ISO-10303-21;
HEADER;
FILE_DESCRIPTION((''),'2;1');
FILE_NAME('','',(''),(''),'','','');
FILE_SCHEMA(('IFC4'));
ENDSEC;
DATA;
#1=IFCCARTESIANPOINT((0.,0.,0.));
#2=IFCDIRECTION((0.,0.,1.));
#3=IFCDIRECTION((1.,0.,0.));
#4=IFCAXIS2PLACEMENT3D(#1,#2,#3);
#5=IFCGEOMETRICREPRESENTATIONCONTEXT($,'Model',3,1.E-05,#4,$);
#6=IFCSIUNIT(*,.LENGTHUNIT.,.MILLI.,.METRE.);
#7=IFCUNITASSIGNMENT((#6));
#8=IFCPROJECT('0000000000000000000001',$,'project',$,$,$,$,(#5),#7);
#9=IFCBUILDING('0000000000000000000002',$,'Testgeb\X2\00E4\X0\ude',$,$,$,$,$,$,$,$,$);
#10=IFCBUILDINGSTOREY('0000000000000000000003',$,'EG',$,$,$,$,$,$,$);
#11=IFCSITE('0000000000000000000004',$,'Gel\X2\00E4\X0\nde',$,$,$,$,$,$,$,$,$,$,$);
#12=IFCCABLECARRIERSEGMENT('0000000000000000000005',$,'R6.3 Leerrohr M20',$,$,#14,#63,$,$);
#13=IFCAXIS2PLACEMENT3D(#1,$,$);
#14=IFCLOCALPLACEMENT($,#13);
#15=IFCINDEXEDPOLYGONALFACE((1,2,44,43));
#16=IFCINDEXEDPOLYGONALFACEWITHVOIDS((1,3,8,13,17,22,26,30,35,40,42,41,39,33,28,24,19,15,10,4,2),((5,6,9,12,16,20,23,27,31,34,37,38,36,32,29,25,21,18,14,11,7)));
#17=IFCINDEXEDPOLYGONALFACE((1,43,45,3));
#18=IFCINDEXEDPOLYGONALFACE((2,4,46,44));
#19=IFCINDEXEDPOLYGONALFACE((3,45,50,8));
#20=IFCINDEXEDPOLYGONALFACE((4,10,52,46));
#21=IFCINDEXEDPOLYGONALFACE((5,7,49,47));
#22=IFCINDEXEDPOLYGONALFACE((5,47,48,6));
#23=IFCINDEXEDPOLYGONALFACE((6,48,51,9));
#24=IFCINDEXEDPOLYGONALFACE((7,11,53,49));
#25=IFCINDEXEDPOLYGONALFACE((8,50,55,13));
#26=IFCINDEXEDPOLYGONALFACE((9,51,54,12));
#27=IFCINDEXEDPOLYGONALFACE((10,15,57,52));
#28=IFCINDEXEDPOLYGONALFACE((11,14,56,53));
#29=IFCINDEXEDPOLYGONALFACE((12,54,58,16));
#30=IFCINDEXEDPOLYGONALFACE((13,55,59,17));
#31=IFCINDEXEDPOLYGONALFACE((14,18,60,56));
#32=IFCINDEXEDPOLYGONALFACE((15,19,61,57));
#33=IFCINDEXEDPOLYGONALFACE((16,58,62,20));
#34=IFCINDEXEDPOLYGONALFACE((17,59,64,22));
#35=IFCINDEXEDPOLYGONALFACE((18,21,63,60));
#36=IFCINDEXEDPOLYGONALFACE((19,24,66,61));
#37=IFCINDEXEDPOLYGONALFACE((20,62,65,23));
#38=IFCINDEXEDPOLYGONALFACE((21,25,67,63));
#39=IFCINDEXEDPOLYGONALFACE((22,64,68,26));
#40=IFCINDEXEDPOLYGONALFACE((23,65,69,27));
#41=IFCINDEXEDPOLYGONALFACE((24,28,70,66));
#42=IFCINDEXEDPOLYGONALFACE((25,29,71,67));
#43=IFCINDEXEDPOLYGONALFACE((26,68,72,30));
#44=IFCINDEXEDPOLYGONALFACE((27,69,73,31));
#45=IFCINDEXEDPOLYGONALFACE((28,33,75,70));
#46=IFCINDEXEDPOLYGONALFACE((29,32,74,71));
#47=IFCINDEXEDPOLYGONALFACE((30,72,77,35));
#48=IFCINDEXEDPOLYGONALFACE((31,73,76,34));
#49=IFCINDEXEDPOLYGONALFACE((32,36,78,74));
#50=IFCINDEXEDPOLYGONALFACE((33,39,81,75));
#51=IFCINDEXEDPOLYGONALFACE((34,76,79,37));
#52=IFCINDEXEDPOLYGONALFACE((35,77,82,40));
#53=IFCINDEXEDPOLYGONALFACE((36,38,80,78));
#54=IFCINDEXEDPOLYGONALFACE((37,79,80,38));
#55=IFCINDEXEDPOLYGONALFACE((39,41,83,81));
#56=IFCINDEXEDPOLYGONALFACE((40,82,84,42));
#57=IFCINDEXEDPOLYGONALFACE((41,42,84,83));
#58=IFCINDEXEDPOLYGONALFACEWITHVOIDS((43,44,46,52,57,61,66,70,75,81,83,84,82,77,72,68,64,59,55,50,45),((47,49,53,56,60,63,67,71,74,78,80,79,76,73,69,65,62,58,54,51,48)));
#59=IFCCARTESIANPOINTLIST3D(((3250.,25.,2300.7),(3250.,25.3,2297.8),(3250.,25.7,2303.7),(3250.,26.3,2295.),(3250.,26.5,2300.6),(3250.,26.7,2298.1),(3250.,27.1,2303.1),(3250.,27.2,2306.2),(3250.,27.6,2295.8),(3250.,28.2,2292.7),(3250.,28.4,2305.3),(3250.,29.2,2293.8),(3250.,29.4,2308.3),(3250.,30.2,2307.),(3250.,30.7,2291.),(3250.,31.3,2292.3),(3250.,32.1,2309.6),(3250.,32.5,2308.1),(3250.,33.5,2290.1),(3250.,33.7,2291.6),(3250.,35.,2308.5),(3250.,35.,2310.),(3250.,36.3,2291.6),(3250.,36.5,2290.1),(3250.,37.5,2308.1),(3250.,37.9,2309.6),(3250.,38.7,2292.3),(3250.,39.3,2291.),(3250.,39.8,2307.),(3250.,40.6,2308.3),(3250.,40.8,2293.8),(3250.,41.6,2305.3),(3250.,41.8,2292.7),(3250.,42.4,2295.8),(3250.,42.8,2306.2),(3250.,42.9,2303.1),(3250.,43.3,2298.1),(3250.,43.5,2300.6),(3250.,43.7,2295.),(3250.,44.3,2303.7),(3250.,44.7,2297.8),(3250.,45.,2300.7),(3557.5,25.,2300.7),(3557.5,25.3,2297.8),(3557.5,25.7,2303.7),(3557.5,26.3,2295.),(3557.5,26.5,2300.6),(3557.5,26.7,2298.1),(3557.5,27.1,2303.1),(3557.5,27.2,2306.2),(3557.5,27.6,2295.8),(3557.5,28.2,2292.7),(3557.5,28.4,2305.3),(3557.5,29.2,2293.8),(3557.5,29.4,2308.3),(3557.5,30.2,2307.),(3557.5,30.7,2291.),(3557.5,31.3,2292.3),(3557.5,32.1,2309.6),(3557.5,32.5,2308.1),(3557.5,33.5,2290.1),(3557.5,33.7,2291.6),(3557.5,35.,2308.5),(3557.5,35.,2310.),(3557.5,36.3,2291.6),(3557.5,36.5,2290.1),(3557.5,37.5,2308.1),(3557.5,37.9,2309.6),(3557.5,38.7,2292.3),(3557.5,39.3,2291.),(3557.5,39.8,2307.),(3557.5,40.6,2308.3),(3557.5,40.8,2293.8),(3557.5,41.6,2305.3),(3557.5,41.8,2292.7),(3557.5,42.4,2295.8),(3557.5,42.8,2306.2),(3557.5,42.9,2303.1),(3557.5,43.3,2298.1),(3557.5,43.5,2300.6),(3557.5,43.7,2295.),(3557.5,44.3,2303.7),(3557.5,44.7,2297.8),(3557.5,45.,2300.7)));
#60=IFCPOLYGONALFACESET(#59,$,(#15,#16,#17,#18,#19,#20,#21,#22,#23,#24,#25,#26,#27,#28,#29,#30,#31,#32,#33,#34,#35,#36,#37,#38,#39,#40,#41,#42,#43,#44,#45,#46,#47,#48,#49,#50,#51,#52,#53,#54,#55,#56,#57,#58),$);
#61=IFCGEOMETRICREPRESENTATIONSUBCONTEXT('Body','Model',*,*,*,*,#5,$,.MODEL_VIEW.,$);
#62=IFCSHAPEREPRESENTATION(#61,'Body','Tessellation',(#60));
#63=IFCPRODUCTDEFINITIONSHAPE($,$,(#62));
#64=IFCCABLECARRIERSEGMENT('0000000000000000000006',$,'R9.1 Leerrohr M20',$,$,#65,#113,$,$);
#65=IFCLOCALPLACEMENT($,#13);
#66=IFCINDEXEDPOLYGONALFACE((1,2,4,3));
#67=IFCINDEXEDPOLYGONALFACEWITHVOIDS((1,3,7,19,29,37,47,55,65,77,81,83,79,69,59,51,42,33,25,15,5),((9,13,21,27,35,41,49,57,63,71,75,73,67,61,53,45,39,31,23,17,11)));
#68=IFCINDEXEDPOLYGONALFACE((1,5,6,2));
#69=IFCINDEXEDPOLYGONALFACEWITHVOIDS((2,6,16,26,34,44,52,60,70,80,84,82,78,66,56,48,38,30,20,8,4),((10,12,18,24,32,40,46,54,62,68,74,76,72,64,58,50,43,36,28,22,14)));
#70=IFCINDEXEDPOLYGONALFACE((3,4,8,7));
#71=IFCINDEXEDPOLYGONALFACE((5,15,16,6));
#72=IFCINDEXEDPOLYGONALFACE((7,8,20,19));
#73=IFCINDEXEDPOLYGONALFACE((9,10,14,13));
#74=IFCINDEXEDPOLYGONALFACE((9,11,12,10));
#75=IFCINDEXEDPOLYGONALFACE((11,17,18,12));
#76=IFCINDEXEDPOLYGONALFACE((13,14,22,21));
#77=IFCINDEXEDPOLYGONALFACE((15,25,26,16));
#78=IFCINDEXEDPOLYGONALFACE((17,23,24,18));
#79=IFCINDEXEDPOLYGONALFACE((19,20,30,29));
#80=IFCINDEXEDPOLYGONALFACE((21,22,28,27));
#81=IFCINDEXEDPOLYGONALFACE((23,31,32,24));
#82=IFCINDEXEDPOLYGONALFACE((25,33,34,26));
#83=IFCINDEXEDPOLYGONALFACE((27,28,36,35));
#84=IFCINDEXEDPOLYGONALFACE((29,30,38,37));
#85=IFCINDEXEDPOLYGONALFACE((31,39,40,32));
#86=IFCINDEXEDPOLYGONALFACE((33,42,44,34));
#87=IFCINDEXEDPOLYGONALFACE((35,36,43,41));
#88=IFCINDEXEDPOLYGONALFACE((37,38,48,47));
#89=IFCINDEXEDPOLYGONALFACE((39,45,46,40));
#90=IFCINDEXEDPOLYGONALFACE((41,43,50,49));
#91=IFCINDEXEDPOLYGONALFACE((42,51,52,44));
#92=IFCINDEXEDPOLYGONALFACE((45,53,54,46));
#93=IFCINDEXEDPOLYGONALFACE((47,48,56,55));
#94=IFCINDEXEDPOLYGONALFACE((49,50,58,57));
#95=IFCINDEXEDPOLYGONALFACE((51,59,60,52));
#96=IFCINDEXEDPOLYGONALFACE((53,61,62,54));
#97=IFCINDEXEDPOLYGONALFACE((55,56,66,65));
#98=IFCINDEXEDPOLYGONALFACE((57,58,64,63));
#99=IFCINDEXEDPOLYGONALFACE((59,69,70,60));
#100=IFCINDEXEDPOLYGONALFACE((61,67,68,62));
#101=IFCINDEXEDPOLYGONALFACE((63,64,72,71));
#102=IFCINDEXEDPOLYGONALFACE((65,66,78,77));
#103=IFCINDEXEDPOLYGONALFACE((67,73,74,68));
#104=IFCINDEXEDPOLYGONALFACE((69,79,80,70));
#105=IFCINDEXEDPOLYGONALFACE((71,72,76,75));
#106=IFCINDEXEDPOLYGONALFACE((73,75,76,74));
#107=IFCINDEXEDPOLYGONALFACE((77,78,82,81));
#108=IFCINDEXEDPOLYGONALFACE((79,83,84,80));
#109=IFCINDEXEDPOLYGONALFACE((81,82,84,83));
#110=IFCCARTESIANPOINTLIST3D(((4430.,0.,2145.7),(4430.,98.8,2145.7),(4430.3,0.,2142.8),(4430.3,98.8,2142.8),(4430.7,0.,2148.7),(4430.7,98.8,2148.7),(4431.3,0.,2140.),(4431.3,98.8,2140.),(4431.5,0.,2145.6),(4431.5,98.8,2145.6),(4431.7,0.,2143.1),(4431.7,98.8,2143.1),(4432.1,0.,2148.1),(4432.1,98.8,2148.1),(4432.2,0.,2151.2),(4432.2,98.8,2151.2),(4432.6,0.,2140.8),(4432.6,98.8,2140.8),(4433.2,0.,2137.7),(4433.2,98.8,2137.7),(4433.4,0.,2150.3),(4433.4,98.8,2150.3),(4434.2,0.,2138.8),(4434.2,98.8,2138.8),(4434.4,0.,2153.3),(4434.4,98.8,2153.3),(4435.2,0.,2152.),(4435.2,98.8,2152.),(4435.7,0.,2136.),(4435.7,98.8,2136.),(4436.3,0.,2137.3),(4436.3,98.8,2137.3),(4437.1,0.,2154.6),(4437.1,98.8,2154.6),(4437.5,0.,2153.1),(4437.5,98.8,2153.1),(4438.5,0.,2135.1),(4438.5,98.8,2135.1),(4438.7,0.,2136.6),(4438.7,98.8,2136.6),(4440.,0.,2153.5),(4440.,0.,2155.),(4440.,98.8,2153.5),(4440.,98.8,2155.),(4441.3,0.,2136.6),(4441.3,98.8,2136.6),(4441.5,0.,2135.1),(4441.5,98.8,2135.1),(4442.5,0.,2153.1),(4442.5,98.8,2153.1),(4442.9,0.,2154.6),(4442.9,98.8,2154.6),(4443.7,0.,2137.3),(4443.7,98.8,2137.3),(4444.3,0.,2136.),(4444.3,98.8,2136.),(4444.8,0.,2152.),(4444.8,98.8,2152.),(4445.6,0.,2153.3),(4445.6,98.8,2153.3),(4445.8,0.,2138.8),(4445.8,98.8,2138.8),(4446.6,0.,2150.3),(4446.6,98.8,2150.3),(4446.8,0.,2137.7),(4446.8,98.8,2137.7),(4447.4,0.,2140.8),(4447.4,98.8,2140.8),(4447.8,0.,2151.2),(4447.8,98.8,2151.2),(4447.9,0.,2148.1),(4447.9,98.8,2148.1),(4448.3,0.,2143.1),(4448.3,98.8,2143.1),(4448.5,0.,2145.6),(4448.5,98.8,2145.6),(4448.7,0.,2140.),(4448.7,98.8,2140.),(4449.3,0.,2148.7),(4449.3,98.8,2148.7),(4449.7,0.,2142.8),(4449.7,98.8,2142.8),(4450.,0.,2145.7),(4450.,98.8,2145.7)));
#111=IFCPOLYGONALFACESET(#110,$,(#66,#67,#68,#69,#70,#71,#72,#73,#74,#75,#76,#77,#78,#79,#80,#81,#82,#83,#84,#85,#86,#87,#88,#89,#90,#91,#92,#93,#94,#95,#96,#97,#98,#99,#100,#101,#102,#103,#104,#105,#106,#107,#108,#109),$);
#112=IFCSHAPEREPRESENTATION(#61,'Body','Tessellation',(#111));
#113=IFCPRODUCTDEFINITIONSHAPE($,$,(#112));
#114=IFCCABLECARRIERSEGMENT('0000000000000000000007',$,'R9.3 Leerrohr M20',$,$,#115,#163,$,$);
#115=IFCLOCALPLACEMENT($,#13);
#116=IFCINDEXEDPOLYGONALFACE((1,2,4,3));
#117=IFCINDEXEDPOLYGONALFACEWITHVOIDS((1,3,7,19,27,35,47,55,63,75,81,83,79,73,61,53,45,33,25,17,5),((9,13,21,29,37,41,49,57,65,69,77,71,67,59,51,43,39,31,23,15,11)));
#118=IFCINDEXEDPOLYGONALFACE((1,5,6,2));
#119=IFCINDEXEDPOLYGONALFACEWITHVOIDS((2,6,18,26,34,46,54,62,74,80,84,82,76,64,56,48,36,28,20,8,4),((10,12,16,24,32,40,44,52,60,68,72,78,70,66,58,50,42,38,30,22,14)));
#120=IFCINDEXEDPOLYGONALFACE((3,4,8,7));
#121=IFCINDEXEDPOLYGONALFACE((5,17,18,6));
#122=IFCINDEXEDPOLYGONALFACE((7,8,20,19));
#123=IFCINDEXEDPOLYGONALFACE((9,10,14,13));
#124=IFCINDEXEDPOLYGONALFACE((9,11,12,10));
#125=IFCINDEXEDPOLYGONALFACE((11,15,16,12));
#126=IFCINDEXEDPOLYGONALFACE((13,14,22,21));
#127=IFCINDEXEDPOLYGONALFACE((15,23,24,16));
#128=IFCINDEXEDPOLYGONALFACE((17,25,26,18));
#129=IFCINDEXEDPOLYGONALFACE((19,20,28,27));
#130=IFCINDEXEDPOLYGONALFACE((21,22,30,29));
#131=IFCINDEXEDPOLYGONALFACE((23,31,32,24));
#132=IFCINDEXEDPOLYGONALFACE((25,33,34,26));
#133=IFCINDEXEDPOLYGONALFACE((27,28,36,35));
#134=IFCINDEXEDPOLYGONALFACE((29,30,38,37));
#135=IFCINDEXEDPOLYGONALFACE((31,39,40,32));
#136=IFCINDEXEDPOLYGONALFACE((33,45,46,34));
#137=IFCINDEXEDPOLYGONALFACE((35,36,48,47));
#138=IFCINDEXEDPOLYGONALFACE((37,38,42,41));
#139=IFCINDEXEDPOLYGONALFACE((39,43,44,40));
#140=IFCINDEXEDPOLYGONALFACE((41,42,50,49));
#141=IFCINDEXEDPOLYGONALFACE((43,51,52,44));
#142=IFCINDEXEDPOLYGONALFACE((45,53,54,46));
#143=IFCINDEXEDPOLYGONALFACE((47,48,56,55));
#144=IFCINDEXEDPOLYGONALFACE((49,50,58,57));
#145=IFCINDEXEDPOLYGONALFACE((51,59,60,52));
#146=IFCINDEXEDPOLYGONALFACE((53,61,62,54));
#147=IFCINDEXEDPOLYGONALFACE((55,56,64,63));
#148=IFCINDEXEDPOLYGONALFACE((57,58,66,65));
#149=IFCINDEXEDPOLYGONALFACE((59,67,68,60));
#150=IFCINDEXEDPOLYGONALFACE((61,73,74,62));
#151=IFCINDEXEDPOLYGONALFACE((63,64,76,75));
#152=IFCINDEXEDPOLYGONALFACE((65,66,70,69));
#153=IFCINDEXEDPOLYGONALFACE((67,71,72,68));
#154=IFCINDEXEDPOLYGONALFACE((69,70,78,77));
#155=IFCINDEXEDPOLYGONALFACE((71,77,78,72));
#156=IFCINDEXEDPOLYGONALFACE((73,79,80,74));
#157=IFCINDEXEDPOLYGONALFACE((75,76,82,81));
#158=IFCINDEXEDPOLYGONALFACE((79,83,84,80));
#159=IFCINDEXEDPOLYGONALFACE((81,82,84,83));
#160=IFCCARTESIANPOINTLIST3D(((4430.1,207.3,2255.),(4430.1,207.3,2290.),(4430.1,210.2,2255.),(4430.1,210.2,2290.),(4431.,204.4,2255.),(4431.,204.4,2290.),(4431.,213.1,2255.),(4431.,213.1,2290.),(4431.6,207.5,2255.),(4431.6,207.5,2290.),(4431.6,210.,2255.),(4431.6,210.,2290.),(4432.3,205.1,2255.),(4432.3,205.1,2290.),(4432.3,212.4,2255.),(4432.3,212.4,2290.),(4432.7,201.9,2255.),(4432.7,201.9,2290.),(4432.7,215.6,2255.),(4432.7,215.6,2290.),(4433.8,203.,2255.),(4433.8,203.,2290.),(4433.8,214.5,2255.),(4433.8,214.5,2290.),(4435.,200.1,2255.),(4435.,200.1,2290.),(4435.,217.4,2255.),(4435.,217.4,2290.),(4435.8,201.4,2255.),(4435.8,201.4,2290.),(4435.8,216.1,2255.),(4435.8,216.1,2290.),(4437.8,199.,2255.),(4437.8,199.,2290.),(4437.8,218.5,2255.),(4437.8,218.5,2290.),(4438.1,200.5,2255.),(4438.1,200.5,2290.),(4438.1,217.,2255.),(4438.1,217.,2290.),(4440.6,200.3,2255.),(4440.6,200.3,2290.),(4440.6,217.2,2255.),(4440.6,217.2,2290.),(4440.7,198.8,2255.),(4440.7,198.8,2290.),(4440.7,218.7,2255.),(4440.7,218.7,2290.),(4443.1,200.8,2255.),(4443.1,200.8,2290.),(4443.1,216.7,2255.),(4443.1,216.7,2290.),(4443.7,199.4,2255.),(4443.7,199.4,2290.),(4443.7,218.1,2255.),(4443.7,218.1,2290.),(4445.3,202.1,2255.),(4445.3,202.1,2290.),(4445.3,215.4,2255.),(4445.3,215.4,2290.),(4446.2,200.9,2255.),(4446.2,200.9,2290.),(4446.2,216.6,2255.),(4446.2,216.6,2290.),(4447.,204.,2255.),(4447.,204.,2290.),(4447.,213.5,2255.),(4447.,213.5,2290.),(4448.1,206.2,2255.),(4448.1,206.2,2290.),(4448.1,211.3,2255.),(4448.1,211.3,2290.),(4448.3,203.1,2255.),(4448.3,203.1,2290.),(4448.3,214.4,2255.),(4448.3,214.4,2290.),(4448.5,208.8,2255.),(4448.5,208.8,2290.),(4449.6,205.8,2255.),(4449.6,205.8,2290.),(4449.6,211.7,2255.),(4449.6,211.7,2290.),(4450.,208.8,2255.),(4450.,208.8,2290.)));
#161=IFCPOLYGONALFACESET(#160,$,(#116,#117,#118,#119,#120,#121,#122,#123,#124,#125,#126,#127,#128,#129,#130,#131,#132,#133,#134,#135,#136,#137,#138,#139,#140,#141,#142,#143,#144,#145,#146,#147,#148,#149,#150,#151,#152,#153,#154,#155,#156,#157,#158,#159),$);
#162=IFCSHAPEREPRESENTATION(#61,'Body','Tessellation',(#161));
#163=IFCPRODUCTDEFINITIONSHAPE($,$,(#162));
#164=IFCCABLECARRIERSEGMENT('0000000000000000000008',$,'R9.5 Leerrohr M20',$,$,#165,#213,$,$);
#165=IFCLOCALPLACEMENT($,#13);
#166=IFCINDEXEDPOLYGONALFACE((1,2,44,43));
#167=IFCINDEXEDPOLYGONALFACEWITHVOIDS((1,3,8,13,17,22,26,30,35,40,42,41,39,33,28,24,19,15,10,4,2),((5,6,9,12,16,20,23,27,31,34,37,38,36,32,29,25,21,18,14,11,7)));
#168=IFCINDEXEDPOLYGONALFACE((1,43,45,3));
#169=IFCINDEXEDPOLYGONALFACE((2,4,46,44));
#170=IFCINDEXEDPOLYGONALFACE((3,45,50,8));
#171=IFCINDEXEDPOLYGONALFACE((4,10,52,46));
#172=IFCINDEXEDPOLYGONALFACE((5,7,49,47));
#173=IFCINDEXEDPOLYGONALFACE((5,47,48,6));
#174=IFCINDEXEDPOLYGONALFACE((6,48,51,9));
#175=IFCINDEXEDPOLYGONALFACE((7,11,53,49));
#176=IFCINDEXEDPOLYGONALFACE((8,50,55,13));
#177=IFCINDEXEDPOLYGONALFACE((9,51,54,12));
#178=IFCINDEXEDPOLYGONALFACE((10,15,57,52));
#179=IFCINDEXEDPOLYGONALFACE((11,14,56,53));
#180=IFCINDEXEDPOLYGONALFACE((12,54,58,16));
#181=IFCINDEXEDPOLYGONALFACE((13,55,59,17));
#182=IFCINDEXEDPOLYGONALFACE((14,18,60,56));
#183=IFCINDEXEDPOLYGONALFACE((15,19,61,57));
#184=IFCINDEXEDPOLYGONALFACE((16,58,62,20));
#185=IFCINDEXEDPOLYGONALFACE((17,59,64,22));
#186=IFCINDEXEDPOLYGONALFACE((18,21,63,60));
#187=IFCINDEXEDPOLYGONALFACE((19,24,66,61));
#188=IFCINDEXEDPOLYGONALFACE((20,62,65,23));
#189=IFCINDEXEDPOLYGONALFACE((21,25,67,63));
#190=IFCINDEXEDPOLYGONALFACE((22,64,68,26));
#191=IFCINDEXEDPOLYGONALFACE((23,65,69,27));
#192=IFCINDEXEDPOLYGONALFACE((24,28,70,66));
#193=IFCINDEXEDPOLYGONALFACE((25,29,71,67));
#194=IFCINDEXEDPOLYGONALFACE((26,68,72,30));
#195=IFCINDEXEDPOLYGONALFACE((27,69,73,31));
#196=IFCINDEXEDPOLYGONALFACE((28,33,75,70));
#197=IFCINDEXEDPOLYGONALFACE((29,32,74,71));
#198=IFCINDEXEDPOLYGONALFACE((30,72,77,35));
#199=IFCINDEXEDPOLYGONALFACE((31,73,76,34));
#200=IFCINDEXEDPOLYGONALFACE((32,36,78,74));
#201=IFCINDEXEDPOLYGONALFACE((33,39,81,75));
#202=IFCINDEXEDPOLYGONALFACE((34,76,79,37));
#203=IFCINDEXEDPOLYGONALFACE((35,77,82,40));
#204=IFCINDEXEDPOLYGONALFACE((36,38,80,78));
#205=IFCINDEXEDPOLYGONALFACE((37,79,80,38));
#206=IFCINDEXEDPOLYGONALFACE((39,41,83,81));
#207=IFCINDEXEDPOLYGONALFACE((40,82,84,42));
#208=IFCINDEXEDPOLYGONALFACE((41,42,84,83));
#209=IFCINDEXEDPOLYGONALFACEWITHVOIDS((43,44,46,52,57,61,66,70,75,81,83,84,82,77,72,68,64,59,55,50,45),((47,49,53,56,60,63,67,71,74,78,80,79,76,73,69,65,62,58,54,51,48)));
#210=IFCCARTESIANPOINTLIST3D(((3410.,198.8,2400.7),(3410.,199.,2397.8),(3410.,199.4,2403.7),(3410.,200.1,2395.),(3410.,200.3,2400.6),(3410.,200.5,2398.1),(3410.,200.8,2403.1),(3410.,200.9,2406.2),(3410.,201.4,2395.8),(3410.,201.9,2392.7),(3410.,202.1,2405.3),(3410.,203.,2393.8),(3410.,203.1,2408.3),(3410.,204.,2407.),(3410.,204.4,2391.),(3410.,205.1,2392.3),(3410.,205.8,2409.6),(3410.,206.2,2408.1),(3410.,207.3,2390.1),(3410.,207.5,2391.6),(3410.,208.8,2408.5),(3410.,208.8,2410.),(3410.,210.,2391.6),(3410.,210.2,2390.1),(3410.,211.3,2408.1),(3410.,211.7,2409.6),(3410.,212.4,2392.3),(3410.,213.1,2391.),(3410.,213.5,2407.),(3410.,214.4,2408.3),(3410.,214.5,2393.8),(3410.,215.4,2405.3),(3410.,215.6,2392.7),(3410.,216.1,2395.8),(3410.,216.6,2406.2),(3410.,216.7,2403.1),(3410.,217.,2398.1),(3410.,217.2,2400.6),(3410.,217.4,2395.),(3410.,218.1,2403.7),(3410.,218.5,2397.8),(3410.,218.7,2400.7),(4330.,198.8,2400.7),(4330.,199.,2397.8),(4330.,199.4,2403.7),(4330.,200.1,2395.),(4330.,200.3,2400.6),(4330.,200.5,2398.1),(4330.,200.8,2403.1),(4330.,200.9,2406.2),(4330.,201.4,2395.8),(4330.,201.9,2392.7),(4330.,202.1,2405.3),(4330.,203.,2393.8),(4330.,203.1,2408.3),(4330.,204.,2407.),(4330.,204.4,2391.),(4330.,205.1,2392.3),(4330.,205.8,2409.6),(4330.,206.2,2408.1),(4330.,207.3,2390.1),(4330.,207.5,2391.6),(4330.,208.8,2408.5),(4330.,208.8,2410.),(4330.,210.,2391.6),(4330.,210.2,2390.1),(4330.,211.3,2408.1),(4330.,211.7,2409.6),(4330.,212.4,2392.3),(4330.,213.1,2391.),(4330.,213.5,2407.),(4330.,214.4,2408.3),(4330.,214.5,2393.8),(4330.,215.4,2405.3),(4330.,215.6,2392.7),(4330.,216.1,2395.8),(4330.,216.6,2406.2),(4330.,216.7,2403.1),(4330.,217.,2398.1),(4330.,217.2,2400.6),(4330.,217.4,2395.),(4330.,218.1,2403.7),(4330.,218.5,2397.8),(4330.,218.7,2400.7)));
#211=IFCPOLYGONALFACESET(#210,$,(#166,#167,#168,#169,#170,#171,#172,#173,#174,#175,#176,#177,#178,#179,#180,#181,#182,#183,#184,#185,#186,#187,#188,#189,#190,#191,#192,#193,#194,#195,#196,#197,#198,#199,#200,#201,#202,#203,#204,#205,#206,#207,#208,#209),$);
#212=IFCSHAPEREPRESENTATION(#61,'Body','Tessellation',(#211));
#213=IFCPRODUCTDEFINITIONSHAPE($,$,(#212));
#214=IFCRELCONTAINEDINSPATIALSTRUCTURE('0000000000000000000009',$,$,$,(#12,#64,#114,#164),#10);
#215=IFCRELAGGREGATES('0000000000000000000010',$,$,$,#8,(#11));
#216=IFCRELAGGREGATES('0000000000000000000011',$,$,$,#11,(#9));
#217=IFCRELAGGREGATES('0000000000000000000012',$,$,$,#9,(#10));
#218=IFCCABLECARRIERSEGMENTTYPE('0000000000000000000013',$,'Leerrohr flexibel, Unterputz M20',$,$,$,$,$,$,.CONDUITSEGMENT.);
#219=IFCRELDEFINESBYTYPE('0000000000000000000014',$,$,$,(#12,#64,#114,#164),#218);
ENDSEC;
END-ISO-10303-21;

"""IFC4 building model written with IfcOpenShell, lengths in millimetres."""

from ifc_helpers import new_model, si_unit, frame, origin_with_axes, place, context, subcontext, project, spatial, hollow_circle, extrude, type_object, element, save


model = new_model("IFC4")

# Units and contexts
model_context = context("Model", 3, precision=1e-05, world=origin_with_axes())
body_context = subcontext(model_context, "Body", "Model", "MODEL_VIEW")
ifc_project = project(units=[si_unit("LENGTHUNIT", "METRE", prefix="MILLI")], contexts=[model_context])

# Site, building, storey
site = spatial("IfcSite", under=ifc_project, Name="Gelände")
building = spatial("IfcBuilding", under=site, Name="Testgebäude")
storey = spatial("IfcBuildingStorey", under=building, Name="EG")

# Cable carrier segments
cable_carrier_segment_type_1 = type_object("IfcCableCarrierSegmentType", Name="Leerrohr flexibel, Unterputz M20", PredefinedType="CONDUITSEGMENT")
cable_carrier_segment_1_placement = place(None, frame((3557.5, 35.0, 2300.0), z_axis=(-1.0, 0.0, 0.0), x_axis=(0.0, 0.0, 1.0)))
element("IfcCableCarrierSegment", 1, at=cable_carrier_segment_1_placement, inside=storey, type_object=cable_carrier_segment_type_1, Name="R6.3 Leerrohr M20", context=body_context, shape_type="SweptSolid", body=[
    extrude(hollow_circle(Radius=10.0, WallThickness=1.5), None, (0.0, 0.0, 1.0), 307.5),
])
cable_carrier_segment_2_placement = place(None, frame((4440.0, 0.0, 2145.0), z_axis=(0.0, 1.0, 0.0), x_axis=(0.0, 0.0, 1.0)))
element("IfcCableCarrierSegment", 2, at=cable_carrier_segment_2_placement, inside=storey, type_object=cable_carrier_segment_type_1, Name="R9.1 Leerrohr M20", context=body_context, shape_type="SweptSolid", body=[
    extrude(hollow_circle(Radius=10.0, WallThickness=1.5), None, (0.0, 0.0, 1.0), 98.8),
])
cable_carrier_segment_3_placement = place(None, frame((4440.0, 208.8, 2255.0), z_axis=(0.0, 0.0, 1.0), x_axis=(1.0, 0.0, 0.0)))
element("IfcCableCarrierSegment", 3, at=cable_carrier_segment_3_placement, inside=storey, type_object=cable_carrier_segment_type_1, Name="R9.3 Leerrohr M20", context=body_context, shape_type="SweptSolid", body=[
    extrude(hollow_circle(Radius=10.0, WallThickness=1.5), None, (0.0, 0.0, 1.0), 35.0),
])
cable_carrier_segment_4_placement = place(None, frame((4330.0, 208.8, 2400.0), z_axis=(-1.0, 0.0, 0.0), x_axis=(0.0, 0.0, 1.0)))
element("IfcCableCarrierSegment", 4, at=cable_carrier_segment_4_placement, inside=storey, type_object=cable_carrier_segment_type_1, Name="R9.5 Leerrohr M20", context=body_context, shape_type="SweptSolid", body=[
    extrude(hollow_circle(Radius=10.0, WallThickness=1.5), None, (0.0, 0.0, 1.0), 920.0),
])

save(model, "model.ifc")
